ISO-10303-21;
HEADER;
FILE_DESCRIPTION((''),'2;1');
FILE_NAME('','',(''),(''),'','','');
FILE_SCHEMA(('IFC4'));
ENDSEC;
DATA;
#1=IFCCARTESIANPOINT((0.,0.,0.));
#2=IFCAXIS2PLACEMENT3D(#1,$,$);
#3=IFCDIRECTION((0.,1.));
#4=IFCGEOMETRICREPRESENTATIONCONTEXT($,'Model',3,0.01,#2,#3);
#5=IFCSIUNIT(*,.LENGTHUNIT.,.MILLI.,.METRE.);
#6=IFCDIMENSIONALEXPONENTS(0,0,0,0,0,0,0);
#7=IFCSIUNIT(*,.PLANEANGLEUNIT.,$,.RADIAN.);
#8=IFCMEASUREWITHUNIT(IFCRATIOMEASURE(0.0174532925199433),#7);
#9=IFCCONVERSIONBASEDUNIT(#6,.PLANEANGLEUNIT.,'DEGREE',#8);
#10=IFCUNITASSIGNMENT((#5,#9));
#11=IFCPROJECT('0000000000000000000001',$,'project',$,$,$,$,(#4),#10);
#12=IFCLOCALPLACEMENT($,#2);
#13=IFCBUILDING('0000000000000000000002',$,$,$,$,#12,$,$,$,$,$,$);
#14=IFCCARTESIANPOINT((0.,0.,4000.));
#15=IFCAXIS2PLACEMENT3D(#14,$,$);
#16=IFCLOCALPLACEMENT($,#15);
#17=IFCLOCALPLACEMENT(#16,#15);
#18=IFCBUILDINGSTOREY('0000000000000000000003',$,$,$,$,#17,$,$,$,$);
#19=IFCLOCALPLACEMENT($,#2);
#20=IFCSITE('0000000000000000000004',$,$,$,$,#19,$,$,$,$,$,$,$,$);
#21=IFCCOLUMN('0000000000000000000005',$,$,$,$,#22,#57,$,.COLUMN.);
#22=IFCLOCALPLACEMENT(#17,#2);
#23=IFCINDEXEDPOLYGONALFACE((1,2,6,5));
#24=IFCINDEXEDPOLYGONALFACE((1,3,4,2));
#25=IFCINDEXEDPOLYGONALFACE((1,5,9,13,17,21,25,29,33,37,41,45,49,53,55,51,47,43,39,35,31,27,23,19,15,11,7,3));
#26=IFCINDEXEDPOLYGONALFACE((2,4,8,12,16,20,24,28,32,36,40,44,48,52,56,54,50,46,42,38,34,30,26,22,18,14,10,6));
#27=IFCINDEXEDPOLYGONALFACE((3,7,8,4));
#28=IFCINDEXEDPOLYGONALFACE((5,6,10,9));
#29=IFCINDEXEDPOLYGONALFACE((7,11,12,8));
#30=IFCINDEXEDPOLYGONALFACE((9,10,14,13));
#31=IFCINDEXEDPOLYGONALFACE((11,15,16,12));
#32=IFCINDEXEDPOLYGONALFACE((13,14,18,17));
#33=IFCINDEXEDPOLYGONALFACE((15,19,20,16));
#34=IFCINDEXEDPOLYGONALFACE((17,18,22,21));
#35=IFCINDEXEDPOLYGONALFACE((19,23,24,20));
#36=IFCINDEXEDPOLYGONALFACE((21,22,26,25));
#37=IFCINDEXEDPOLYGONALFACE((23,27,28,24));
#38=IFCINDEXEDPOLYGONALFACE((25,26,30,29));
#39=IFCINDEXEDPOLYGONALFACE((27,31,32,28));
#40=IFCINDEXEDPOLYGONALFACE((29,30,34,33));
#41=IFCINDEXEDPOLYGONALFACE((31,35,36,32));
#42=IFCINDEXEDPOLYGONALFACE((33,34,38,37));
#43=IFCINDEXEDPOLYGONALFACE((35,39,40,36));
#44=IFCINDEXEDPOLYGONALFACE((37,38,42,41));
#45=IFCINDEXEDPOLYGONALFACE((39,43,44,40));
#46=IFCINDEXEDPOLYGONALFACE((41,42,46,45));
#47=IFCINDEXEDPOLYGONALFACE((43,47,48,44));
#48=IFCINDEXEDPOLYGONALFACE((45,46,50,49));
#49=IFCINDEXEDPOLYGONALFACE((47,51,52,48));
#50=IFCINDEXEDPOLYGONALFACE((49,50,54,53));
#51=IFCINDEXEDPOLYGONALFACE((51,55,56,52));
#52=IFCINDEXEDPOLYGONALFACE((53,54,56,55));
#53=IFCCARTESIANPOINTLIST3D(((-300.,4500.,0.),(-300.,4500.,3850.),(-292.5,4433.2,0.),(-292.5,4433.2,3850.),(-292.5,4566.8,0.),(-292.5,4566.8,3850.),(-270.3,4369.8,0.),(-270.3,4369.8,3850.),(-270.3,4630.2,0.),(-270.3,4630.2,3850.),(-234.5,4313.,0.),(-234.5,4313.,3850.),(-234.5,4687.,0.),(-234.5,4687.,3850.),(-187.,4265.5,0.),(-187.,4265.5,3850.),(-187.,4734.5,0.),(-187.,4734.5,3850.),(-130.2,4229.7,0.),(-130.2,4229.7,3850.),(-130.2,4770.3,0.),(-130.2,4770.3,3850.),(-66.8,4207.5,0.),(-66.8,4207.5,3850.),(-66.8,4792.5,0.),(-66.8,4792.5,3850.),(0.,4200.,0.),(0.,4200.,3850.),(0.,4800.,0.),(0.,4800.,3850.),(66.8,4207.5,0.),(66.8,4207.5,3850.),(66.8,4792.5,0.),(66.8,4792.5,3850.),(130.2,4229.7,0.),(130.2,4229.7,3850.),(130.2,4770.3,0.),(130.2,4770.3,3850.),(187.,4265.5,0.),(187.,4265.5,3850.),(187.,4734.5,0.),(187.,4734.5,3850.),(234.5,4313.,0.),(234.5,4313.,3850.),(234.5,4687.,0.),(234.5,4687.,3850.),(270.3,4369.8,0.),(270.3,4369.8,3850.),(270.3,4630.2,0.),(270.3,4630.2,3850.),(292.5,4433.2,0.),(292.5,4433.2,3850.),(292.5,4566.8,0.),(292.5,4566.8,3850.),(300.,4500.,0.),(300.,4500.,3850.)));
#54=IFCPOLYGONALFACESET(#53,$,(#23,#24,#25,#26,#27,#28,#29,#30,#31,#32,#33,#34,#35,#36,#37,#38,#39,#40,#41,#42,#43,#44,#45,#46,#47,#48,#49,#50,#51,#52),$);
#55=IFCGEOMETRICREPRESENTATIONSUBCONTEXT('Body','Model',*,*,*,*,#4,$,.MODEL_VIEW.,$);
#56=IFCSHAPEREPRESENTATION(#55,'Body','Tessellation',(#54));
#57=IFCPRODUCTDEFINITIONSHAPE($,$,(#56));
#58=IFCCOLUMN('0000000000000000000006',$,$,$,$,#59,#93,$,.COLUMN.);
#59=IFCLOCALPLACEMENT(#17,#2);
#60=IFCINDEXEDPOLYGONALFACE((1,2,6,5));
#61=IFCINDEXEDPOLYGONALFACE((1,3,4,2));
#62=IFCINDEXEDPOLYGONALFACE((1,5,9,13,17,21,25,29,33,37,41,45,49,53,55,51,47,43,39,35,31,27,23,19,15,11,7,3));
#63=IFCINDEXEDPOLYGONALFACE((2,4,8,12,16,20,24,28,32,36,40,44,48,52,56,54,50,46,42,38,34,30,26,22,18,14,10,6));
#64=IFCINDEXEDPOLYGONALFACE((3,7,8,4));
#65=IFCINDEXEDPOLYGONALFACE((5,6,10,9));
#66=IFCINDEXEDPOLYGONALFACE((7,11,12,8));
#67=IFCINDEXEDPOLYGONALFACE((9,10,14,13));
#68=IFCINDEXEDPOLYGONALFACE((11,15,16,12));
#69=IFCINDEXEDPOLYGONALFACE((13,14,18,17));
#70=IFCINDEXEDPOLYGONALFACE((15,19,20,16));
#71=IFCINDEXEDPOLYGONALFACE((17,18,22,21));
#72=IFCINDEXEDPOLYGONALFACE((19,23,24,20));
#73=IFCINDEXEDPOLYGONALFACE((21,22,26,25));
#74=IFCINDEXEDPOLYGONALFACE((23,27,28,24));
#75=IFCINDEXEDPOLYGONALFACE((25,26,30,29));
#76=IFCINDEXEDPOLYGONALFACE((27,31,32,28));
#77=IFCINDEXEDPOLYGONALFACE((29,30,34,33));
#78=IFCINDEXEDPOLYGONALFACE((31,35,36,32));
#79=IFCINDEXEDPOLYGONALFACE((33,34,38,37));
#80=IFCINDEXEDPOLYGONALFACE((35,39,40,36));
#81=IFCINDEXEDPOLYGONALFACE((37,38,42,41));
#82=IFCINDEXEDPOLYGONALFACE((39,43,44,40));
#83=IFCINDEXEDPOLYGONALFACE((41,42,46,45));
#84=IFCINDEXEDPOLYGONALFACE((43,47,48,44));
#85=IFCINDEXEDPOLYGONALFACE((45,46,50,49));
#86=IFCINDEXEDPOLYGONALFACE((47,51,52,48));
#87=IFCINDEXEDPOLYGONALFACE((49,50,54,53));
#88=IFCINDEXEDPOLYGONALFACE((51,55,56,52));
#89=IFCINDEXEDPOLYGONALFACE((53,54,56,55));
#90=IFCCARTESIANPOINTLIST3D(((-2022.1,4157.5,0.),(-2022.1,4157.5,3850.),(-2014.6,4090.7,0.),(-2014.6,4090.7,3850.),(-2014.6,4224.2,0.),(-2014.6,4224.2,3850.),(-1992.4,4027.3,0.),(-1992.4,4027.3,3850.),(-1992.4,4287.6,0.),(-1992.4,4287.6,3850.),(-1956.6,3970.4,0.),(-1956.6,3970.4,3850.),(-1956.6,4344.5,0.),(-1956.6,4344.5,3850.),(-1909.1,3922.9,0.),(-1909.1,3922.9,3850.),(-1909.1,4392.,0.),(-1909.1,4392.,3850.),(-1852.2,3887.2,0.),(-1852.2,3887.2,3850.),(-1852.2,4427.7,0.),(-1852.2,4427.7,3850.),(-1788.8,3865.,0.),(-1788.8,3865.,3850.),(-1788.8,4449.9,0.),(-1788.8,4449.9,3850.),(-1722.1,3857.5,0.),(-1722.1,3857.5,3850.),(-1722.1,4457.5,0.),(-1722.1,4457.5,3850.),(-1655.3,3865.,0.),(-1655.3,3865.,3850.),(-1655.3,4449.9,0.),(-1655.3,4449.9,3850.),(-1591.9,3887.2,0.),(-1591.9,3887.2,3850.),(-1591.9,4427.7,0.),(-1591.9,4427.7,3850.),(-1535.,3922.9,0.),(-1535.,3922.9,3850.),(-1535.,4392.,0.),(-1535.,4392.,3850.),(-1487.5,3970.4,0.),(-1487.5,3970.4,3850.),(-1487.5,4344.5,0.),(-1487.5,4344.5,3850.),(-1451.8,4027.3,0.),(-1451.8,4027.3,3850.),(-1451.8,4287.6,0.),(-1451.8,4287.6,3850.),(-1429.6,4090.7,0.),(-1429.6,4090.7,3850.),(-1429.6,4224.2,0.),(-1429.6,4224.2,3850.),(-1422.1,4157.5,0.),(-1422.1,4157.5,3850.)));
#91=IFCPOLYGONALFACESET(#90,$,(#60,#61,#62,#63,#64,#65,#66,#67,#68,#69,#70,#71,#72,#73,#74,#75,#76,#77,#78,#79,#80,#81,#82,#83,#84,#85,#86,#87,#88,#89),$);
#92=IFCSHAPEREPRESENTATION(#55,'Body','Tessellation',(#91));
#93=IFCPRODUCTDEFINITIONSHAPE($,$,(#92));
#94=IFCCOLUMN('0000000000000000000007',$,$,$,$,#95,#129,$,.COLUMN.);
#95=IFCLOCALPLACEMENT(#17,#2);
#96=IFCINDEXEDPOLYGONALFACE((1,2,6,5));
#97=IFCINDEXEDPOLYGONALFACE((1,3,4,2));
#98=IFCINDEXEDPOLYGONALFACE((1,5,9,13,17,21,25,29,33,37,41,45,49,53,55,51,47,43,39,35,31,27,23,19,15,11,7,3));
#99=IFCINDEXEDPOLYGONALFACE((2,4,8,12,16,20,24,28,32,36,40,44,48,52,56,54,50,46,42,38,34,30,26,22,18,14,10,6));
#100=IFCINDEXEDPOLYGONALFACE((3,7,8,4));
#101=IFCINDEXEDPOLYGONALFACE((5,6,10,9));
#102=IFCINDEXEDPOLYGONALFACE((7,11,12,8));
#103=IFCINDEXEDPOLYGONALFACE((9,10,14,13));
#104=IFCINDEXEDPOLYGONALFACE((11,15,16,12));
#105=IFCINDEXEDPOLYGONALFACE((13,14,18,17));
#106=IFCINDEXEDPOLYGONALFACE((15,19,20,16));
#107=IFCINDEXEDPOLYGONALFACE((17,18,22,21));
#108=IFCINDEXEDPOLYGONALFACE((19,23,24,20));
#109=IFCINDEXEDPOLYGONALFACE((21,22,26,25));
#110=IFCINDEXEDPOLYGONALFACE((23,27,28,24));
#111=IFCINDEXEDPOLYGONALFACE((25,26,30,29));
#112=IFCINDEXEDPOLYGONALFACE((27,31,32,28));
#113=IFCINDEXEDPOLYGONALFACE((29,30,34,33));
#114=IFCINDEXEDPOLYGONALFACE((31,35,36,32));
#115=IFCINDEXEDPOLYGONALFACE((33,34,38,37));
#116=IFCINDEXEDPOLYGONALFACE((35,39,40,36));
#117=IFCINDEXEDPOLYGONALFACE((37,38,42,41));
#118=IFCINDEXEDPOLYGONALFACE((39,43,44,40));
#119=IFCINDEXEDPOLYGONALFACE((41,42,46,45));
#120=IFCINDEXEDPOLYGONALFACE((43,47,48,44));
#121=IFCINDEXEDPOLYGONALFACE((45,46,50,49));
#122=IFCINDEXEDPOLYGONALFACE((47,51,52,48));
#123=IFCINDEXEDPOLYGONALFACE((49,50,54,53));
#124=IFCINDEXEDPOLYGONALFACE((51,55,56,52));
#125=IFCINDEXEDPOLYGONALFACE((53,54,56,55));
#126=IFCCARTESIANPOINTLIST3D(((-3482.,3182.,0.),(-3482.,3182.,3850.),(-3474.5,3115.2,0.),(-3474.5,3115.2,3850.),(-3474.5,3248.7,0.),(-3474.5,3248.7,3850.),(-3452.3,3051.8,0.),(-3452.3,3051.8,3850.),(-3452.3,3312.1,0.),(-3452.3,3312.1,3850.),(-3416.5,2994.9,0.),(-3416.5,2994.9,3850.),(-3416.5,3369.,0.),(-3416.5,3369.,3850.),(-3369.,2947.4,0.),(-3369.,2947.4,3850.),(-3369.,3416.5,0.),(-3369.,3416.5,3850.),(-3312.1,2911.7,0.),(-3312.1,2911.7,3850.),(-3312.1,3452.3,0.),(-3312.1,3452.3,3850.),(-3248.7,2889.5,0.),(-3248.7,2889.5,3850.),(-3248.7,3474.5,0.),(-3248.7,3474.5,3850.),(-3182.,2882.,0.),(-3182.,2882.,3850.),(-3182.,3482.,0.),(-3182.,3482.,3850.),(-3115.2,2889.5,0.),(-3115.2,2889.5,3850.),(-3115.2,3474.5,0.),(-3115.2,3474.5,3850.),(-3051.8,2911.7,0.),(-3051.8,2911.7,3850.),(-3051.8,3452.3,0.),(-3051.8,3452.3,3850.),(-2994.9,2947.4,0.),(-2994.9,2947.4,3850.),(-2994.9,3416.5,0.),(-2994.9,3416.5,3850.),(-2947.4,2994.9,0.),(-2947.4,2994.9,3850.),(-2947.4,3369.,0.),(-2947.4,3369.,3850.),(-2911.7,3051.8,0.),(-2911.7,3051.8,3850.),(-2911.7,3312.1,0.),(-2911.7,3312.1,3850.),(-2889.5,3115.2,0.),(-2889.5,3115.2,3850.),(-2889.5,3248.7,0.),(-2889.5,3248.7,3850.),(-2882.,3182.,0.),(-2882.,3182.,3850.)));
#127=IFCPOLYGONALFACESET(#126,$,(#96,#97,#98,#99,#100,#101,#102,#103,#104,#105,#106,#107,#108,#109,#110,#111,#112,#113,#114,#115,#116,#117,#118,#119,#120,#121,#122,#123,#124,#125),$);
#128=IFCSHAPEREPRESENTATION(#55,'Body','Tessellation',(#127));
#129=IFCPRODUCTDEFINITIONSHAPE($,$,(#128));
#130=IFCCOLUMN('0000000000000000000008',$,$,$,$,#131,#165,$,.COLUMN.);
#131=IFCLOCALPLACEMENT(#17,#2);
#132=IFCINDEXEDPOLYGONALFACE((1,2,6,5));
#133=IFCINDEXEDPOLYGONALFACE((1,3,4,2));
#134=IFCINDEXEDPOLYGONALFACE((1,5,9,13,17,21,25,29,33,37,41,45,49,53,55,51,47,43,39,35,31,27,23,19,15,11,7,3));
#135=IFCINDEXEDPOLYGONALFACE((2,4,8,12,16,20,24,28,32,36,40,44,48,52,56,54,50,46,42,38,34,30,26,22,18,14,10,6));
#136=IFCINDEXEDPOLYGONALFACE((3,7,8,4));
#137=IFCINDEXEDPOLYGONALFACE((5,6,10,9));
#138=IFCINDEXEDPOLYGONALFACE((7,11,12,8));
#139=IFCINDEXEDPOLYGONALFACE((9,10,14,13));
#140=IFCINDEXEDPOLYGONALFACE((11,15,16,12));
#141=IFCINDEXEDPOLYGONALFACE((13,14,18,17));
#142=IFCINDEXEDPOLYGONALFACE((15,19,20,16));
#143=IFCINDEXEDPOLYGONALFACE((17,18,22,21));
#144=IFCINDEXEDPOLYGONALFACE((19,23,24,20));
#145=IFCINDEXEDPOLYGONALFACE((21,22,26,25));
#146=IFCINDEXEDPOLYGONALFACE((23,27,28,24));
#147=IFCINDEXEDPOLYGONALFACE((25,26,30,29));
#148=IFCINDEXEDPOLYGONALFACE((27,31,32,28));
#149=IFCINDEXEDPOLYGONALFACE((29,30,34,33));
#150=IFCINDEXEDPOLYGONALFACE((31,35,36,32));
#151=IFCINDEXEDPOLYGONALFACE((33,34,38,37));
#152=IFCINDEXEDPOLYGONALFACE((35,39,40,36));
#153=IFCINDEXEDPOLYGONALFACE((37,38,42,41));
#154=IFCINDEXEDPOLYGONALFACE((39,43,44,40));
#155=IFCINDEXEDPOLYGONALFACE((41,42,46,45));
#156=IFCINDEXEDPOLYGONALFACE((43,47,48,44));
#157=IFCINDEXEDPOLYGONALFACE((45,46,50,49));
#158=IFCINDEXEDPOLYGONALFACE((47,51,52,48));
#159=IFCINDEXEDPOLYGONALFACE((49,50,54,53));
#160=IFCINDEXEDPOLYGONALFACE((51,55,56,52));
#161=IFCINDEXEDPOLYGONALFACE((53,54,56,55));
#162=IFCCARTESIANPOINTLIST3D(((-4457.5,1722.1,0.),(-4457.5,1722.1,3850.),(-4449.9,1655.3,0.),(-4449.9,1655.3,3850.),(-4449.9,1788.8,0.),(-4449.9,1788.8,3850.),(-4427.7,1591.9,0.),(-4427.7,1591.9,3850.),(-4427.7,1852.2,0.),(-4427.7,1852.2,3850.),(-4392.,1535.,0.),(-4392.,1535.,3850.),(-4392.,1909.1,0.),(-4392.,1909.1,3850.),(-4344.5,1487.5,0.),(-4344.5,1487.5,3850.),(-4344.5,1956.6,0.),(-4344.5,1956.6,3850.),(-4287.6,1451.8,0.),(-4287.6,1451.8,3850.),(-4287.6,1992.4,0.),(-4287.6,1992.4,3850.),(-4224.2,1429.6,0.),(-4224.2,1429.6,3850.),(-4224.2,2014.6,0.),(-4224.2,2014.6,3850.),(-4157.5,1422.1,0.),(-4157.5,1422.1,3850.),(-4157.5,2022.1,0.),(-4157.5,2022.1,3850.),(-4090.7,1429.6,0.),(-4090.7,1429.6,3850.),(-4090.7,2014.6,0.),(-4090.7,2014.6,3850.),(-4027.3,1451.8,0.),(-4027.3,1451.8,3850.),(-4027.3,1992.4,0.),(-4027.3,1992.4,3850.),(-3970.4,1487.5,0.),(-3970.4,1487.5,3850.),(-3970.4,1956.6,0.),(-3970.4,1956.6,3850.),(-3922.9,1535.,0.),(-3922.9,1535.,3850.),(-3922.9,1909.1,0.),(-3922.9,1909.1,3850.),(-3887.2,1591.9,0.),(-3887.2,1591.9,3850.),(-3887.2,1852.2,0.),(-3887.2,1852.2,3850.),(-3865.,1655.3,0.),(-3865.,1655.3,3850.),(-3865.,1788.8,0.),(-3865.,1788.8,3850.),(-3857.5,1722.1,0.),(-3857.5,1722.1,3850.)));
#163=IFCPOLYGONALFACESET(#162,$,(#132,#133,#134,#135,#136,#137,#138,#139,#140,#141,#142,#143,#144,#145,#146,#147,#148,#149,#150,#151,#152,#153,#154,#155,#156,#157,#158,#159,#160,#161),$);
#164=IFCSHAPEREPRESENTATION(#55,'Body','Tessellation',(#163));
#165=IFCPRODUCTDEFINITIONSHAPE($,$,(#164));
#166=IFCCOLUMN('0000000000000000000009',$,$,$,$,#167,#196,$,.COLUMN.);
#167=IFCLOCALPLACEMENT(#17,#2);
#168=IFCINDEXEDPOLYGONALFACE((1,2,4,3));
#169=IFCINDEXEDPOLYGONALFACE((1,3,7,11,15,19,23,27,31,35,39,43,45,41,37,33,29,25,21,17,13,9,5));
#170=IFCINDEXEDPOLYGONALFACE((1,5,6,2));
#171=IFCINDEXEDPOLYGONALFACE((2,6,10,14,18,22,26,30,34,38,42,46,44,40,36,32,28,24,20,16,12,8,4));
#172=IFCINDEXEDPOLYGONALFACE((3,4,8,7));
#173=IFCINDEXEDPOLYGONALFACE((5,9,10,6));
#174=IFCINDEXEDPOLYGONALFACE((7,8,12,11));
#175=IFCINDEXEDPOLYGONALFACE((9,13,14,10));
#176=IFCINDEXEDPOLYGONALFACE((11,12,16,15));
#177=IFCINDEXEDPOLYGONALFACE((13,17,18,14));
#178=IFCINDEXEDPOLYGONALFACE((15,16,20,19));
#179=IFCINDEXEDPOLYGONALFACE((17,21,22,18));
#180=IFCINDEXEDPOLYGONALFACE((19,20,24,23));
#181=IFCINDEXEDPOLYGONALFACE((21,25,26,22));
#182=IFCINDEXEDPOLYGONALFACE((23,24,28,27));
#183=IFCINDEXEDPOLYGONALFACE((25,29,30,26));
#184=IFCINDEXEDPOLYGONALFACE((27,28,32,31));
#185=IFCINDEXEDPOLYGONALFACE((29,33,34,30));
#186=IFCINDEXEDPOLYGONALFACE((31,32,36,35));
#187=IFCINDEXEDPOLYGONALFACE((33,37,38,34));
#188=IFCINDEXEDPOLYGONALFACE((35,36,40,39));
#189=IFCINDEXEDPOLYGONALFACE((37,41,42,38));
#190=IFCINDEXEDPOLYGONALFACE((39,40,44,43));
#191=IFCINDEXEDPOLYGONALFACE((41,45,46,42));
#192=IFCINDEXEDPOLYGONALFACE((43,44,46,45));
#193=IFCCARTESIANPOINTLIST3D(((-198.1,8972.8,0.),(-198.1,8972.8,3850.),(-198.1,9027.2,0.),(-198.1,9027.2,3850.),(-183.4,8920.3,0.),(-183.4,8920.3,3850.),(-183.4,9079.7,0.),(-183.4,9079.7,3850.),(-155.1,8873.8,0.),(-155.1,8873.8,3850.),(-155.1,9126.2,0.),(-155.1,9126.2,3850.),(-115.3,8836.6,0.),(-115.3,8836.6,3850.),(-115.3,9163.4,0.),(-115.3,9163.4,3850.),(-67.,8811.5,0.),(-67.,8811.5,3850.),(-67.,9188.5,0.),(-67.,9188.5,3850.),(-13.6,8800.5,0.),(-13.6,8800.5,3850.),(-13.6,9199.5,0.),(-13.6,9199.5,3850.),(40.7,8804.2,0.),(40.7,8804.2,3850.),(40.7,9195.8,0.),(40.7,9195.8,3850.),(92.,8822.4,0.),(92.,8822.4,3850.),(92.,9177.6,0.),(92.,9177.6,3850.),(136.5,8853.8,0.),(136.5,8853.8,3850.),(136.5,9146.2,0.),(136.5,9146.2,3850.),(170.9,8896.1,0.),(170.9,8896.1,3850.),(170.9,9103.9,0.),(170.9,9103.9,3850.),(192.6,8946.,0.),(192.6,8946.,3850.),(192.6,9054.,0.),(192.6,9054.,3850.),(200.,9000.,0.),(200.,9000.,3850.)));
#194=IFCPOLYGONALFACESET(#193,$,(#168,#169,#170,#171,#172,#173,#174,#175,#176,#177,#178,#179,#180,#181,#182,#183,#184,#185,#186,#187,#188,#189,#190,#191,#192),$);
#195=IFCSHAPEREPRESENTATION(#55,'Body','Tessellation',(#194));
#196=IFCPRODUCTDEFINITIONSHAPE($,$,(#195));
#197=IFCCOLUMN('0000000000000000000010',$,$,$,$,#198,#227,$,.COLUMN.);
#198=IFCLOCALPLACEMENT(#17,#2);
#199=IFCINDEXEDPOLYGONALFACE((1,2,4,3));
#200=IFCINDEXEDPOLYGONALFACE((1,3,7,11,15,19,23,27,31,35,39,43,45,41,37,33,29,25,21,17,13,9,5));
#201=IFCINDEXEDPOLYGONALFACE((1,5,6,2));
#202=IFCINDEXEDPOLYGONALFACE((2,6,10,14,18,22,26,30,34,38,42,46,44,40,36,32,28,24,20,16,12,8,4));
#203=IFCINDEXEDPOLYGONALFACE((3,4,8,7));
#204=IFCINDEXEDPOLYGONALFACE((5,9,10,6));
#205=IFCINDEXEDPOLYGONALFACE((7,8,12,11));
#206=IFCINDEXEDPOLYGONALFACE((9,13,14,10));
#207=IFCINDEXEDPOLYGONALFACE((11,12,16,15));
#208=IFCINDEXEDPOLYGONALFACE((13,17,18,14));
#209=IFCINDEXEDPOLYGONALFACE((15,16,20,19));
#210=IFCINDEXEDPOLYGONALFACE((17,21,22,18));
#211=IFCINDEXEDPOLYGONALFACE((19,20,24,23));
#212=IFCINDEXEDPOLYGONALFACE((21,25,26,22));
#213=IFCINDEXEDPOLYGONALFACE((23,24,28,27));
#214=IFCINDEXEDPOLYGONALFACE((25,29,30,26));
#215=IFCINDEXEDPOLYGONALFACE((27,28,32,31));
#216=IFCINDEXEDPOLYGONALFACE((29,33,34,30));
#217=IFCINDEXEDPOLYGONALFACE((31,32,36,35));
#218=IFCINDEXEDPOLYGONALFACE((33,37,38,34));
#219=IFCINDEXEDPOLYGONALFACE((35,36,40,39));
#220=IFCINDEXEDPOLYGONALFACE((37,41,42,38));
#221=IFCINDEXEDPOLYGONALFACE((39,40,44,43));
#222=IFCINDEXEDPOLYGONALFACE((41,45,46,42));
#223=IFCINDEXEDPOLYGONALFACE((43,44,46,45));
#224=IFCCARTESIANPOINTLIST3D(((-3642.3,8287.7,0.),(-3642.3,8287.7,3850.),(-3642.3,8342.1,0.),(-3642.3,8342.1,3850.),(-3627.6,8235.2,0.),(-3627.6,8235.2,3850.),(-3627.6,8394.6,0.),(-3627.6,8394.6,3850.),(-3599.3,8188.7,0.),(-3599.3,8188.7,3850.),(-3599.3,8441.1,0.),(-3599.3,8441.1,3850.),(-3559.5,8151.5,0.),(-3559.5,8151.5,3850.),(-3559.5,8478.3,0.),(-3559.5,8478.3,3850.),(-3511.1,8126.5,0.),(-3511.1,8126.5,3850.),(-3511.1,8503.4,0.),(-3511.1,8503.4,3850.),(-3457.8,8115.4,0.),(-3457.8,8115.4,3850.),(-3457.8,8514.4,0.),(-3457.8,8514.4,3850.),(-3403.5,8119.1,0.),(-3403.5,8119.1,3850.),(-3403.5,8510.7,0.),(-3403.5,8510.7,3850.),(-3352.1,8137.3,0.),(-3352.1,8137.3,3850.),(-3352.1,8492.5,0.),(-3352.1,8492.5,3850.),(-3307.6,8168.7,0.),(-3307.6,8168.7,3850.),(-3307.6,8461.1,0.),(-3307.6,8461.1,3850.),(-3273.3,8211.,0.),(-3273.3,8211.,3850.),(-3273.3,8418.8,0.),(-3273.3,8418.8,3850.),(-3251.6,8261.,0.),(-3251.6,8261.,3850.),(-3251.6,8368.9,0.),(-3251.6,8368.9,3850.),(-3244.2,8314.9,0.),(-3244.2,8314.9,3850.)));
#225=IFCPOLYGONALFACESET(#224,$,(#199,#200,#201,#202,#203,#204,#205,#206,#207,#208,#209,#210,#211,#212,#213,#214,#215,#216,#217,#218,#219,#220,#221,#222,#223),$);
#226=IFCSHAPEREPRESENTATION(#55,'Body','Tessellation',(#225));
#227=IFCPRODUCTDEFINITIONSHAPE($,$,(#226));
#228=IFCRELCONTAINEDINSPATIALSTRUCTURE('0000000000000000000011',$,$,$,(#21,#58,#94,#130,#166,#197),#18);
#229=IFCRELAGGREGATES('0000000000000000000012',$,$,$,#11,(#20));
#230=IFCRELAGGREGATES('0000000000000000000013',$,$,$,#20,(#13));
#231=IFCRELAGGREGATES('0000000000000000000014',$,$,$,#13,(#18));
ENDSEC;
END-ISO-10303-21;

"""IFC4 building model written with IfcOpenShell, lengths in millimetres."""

from ifc_helpers import new_model, entity, si_unit, converted_unit, direction, frame, origin, origin_2d, place, context, subcontext, project, spatial, circle, extrude, element, save


model = new_model("IFC4")

# Units and contexts
model_context = context("Model", 3, precision=0.01, world=origin(), true_north=direction((0.0, 1.0)))
body_context = subcontext(model_context, "Body", "Model", "MODEL_VIEW")
ifc_project = project(units=[si_unit("LENGTHUNIT", "METRE", prefix="MILLI"), converted_unit("PLANEANGLEUNIT", "DEGREE", entity("IfcRatioMeasure", 0.0174532925199433), si_unit("PLANEANGLEUNIT", "RADIAN"), dimensions=[0, 0, 0, 0, 0, 0, 0])], contexts=[model_context])

# Site, building, storey
site_placement = place(None, origin())
site = spatial("IfcSite", under=ifc_project, at=site_placement)
building_placement = place(None, origin())
building = spatial("IfcBuilding", under=site, at=building_placement)
placement = place(None, frame((0.0, 0.0, 4000.0)))
storey_placement = place(placement, frame((0.0, 0.0, 4000.0)))
storey = spatial("IfcBuildingStorey", under=building, at=storey_placement)

# Columns
for number, where in (
    (1, (0.0, 4500.0, 0.0)),
    (2, (-1722.1, 4157.5, 0.0)),
    (3, (-3182.0, 3182.0, 0.0)),
    (4, (-4157.5, 1722.1, 0.0)),
):
    element("IfcColumn", number, at=place(storey_placement, frame(where)), inside=storey, PredefinedType="COLUMN", context=body_context, shape_type="SweptSolid", body=[
        extrude(circle(Radius=300.0, at=origin_2d()), origin(), (0.0, 0.0, 1.0), 3850.0),
    ])
for number, where in (
    (5, (0.0, 9000.0, 0.0)),
    (6, (-3444.2, 8314.9, 0.0)),
):
    element("IfcColumn", number, at=place(storey_placement, frame(where)), inside=storey, PredefinedType="COLUMN", context=body_context, shape_type="SweptSolid", body=[
        extrude(circle(Radius=200.0, at=origin_2d()), origin(), (0.0, 0.0, 1.0), 3850.0),
    ])

save(model, "model.ifc")
